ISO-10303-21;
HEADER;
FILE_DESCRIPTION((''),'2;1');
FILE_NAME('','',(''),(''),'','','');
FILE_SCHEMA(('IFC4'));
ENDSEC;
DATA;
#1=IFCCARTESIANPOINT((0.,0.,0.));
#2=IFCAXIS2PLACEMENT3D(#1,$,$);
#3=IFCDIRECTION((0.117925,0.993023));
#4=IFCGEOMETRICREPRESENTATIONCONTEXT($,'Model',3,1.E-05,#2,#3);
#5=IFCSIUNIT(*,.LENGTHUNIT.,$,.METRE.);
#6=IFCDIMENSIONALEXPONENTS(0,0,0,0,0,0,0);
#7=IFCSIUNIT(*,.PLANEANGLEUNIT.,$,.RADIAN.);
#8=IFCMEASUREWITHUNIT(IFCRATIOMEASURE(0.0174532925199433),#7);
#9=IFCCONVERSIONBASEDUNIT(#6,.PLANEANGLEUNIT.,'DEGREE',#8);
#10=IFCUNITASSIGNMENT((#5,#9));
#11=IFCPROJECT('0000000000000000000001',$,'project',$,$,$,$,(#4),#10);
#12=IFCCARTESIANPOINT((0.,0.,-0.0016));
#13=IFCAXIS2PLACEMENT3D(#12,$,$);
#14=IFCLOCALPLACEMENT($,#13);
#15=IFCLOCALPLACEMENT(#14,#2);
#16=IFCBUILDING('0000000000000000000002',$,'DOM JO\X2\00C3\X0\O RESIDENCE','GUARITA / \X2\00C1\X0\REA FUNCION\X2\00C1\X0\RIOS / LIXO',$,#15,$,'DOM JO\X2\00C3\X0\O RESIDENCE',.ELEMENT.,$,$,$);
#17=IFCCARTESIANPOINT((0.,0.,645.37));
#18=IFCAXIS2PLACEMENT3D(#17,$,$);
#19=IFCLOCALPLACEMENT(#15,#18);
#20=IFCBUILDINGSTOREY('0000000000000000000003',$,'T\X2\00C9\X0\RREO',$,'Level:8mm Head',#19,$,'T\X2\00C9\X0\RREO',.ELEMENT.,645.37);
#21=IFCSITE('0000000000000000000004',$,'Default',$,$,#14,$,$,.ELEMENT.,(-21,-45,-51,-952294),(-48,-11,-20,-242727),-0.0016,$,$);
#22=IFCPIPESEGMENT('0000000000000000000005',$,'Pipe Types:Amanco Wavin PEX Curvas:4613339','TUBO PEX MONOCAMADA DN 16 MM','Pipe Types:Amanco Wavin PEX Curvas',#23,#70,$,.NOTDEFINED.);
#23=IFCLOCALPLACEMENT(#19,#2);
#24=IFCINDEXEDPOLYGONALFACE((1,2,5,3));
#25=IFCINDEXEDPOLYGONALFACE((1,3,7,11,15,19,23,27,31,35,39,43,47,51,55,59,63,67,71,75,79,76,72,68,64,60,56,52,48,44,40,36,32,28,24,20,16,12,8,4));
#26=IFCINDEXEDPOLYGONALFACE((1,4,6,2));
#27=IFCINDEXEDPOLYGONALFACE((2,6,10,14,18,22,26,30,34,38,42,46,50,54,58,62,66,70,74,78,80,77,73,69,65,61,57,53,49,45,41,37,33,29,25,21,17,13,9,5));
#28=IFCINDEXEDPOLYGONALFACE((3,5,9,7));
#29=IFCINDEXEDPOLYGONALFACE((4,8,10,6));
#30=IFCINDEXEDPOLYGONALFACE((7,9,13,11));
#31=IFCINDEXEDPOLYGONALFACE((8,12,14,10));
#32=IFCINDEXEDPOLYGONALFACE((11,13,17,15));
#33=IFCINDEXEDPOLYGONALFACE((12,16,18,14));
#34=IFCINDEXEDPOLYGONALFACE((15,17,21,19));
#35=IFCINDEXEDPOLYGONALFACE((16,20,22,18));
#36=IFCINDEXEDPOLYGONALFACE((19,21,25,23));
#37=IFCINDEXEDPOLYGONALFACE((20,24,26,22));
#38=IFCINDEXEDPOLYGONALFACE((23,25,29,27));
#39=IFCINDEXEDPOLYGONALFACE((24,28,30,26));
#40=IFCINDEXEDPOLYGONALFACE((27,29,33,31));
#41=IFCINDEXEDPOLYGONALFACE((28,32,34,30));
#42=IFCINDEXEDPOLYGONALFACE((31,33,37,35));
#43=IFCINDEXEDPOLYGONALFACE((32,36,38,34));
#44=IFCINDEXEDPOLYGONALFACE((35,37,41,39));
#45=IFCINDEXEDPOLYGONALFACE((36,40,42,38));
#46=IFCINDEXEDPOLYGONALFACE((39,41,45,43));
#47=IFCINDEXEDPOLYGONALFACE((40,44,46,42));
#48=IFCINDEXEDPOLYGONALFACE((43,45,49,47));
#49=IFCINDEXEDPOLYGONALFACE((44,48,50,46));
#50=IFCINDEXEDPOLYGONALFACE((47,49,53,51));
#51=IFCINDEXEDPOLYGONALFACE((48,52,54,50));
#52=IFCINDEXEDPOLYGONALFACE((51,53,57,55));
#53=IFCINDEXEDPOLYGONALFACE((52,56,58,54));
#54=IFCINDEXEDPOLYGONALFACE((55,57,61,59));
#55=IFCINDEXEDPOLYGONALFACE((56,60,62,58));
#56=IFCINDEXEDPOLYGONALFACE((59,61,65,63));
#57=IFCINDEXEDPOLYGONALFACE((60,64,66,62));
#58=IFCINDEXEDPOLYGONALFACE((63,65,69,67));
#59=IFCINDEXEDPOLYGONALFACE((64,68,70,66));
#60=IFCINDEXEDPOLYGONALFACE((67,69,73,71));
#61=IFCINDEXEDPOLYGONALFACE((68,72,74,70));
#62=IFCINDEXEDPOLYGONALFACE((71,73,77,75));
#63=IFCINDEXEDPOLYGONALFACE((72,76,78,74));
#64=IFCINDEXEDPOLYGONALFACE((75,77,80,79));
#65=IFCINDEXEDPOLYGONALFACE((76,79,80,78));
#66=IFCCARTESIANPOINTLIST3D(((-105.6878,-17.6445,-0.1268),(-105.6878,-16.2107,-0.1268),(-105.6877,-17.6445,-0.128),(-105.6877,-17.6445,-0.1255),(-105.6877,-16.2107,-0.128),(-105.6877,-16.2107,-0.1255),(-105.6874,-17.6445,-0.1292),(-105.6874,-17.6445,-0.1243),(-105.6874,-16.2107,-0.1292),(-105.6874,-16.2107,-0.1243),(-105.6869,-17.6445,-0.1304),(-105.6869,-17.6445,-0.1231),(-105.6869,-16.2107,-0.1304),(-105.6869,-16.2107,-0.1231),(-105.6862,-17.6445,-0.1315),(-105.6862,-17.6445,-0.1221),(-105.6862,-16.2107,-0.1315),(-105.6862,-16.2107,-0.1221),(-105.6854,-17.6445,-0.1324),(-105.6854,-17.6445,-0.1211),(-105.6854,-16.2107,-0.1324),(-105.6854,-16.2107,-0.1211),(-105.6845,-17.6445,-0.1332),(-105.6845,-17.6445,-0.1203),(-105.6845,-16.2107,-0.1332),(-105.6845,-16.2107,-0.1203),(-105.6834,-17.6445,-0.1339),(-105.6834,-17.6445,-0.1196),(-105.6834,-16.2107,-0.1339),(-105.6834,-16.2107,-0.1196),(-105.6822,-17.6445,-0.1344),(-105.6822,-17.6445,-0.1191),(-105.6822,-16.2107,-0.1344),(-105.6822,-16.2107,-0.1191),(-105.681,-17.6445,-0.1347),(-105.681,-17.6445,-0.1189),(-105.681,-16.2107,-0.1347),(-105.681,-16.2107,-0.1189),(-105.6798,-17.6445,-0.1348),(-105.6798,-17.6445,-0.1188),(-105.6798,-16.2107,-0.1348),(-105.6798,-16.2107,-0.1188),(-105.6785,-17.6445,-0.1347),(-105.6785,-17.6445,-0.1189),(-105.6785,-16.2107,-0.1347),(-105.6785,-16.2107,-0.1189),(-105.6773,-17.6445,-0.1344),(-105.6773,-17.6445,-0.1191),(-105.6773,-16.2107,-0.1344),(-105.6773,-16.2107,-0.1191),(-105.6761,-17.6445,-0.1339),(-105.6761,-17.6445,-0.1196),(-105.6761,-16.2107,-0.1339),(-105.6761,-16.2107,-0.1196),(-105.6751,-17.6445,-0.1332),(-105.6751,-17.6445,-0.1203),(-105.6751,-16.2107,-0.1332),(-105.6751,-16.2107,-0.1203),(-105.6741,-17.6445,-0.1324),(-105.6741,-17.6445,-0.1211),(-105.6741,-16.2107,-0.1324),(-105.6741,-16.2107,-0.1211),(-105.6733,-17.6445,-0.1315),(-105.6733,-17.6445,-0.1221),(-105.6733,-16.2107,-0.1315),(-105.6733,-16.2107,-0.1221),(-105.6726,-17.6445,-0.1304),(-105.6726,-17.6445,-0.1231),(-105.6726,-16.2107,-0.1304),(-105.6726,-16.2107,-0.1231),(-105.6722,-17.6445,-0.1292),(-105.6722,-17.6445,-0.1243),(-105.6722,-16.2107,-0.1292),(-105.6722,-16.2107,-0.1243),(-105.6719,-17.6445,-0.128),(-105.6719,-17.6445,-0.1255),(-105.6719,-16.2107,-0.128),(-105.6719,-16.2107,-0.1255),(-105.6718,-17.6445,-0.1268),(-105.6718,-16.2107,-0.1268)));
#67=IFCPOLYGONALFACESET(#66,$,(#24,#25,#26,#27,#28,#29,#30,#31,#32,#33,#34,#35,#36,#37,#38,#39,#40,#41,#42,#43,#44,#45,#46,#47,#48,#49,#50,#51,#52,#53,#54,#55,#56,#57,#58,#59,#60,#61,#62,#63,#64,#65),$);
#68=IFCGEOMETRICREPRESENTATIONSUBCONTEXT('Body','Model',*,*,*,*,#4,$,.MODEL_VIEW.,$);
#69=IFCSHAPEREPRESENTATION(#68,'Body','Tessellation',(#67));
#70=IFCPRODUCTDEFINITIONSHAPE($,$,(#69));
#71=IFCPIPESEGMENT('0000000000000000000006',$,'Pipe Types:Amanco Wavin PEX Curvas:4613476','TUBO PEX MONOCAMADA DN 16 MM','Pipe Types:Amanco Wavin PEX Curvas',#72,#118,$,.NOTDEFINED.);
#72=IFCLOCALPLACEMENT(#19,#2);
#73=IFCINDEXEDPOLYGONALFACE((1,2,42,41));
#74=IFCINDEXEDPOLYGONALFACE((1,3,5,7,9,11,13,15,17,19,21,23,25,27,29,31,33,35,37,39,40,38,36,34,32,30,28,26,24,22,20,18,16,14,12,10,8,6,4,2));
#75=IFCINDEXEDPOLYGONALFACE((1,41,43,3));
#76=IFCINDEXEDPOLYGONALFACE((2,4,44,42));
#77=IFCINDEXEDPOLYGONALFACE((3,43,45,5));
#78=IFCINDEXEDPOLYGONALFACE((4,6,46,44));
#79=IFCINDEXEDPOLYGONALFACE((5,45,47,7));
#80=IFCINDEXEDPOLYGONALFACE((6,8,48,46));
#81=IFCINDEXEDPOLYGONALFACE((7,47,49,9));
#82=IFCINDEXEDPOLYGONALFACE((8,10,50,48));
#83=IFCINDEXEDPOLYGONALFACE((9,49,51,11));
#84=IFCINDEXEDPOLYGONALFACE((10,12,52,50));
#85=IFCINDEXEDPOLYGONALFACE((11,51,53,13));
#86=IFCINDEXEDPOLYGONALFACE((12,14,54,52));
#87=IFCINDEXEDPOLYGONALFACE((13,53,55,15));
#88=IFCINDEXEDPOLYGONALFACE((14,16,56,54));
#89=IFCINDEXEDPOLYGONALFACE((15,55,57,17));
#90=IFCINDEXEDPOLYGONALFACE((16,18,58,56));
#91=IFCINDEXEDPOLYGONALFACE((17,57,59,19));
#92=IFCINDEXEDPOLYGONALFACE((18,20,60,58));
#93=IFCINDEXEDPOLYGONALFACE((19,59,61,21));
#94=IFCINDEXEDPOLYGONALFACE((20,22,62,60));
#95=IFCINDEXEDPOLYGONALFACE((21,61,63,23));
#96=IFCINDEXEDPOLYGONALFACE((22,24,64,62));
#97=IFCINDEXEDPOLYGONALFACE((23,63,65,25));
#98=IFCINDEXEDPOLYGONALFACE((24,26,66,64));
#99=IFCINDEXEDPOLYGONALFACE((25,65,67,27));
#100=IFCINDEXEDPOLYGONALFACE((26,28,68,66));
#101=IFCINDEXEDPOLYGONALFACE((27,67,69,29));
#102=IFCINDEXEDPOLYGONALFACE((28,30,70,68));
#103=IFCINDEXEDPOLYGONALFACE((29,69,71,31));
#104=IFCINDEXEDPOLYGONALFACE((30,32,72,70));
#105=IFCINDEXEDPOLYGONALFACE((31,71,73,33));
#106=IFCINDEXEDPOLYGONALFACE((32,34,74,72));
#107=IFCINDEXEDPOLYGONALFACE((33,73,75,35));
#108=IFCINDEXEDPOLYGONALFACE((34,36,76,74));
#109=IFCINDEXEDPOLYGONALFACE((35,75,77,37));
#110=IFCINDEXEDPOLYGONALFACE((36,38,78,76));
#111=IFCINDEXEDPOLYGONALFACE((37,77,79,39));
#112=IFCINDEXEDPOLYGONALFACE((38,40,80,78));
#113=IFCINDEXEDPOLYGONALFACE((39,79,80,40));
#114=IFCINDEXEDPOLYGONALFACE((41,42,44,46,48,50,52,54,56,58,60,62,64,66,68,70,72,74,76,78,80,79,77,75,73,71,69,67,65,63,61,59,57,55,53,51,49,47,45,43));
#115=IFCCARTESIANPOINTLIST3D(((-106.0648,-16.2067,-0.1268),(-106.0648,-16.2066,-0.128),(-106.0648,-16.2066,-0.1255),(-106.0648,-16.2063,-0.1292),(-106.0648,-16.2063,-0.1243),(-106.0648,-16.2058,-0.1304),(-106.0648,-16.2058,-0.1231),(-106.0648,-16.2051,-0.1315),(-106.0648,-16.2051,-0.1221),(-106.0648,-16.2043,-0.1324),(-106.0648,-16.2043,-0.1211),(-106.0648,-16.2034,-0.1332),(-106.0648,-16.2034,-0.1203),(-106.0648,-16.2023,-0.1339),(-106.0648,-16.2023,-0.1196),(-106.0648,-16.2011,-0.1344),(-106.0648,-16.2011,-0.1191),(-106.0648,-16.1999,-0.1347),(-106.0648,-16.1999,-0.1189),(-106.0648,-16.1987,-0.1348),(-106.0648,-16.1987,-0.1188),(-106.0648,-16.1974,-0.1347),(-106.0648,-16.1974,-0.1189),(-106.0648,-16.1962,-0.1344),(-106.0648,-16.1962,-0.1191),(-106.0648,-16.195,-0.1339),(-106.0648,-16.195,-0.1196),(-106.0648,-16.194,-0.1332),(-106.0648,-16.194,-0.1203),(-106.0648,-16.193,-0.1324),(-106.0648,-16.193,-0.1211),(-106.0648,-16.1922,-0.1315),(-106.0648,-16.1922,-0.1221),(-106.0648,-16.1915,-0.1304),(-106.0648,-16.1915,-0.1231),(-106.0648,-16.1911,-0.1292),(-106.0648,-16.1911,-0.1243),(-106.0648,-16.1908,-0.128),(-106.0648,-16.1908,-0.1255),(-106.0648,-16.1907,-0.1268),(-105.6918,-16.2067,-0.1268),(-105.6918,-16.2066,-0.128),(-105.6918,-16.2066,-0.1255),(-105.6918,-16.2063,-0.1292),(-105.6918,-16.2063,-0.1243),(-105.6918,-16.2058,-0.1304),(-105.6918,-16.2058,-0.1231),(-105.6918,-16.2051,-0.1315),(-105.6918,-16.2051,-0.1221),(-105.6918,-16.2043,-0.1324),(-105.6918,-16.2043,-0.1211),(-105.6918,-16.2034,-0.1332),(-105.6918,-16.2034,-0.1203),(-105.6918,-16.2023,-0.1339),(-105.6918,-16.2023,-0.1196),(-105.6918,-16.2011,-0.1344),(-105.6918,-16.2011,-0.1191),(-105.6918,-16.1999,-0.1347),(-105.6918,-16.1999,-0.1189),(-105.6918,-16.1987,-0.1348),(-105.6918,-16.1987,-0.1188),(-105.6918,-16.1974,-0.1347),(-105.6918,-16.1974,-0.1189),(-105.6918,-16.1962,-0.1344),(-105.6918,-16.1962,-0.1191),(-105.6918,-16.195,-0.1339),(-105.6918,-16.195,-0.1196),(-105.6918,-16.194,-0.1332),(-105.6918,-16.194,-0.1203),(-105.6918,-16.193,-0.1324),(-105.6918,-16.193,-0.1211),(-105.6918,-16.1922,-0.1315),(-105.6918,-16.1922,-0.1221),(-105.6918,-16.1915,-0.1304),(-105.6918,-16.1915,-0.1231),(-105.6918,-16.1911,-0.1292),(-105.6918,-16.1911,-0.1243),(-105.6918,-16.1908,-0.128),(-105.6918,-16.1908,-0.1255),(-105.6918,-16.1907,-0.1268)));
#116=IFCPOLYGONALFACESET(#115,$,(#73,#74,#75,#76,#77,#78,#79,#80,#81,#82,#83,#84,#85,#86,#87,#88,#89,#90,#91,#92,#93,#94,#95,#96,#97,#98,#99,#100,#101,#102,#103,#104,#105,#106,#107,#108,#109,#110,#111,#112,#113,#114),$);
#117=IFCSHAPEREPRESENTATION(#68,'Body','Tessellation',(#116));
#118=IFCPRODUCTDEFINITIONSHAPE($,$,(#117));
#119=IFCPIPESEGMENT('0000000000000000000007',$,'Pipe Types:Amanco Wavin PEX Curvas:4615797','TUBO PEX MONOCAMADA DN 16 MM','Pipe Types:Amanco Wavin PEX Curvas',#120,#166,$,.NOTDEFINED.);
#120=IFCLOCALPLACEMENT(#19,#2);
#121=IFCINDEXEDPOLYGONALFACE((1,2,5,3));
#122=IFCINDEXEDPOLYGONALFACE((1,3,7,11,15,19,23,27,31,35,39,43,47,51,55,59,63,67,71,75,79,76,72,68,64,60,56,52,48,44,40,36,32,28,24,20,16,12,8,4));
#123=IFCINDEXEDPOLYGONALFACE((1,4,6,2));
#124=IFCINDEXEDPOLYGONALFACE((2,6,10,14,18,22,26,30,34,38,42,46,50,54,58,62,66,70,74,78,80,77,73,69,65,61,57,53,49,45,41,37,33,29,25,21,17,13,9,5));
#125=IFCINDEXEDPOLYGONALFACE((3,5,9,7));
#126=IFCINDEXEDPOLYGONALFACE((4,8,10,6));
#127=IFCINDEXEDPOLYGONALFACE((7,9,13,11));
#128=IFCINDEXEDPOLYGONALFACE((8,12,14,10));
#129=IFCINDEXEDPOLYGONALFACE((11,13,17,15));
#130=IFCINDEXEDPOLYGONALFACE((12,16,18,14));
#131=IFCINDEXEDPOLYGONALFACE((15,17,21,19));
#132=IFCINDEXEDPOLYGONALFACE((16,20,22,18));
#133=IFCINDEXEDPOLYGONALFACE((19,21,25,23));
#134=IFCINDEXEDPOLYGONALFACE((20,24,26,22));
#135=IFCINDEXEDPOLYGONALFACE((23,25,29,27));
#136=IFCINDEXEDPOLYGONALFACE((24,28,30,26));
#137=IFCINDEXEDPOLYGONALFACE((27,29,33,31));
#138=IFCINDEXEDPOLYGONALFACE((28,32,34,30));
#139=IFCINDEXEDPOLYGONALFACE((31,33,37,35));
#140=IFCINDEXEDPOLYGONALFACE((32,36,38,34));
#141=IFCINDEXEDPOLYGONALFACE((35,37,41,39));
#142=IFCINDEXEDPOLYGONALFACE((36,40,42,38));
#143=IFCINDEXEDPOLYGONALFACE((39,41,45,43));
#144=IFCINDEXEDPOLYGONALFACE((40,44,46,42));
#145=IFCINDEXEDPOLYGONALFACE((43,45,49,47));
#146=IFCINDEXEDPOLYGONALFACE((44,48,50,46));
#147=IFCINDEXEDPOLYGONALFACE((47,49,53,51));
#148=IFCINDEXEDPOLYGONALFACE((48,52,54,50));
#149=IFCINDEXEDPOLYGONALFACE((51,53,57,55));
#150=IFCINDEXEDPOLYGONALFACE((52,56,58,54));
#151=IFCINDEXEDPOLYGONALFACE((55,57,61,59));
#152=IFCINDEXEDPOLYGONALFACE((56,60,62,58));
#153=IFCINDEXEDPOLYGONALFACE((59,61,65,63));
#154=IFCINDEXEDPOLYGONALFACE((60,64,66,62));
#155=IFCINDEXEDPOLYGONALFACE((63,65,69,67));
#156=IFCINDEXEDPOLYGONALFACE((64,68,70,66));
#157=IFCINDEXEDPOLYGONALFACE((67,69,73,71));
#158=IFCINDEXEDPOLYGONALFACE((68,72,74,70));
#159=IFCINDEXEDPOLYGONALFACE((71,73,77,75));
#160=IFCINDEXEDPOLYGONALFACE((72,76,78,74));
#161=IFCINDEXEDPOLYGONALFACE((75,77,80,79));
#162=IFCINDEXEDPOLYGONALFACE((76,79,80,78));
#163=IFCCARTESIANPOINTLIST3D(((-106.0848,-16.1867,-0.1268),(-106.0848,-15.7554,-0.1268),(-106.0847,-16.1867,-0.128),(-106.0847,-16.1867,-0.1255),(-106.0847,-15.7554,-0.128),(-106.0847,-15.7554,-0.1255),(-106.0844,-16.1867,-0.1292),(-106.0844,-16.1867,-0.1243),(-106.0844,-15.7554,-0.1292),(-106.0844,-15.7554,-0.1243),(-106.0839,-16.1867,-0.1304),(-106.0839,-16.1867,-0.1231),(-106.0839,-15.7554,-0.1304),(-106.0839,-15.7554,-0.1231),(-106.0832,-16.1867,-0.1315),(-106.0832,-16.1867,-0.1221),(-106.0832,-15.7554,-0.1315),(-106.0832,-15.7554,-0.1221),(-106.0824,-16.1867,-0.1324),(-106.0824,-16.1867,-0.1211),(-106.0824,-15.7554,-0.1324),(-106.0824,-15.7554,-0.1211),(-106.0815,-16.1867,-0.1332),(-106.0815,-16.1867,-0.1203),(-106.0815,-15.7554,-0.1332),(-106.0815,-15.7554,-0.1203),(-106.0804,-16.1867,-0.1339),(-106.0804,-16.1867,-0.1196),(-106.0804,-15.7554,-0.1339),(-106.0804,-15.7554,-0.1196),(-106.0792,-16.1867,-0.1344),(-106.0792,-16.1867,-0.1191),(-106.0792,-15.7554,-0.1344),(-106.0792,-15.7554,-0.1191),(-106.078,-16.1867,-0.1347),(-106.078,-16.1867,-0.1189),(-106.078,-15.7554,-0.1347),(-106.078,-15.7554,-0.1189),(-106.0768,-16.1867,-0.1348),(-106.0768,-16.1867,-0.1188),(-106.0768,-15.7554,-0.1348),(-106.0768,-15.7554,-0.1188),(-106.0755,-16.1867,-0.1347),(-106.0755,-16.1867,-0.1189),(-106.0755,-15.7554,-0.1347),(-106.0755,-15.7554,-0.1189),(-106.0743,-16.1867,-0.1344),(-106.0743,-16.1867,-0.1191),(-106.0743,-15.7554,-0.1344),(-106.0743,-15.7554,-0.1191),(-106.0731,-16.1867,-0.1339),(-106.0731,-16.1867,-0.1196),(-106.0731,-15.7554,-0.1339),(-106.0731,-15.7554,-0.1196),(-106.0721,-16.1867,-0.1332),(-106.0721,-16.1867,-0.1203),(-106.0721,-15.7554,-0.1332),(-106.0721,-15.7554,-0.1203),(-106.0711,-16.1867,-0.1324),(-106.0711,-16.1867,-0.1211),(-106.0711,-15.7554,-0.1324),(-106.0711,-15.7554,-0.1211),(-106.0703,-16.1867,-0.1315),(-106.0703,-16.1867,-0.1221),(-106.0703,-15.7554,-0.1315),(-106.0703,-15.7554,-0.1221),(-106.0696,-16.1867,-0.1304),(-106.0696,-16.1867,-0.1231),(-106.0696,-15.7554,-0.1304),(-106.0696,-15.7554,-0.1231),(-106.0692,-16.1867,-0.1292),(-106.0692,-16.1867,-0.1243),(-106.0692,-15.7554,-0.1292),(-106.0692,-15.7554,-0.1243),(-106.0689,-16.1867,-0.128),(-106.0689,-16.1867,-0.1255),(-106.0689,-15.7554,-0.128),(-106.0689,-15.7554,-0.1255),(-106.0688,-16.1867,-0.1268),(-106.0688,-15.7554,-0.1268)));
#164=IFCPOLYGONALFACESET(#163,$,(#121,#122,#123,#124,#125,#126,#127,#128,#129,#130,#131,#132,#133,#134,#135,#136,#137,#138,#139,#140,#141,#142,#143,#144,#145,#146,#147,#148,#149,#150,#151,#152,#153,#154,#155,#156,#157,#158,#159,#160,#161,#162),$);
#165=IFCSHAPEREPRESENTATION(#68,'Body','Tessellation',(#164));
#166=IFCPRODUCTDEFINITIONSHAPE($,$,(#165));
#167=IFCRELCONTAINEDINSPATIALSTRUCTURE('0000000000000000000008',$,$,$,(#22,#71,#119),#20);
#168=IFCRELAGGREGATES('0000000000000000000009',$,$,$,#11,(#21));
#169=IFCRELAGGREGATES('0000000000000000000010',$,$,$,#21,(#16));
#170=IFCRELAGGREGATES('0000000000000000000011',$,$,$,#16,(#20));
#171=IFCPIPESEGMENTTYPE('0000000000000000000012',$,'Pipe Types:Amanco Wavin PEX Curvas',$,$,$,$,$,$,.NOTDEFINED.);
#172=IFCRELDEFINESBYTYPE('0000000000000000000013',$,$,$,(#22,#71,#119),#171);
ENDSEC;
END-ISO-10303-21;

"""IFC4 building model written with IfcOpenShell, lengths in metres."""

from ifc_helpers import new_model, entity, si_unit, converted_unit, direction, frame, origin, place, context, subcontext, project, spatial, indexed_curve, outline, extrude, type_object, element, save


model = new_model("IFC4")

# Units and contexts
model_context = context("Model", 3, precision=1e-05, world=origin(), true_north=direction((0.117925, 0.993023)))
body_context = subcontext(model_context, "Body", "Model", "MODEL_VIEW")
ifc_project = project(units=[si_unit("LENGTHUNIT", "METRE"), converted_unit("PLANEANGLEUNIT", "DEGREE", entity("IfcRatioMeasure", 0.0174532925199433), si_unit("PLANEANGLEUNIT", "RADIAN"), dimensions=[0, 0, 0, 0, 0, 0, 0])], contexts=[model_context])

# Site, building, storey
site_placement = place(None, frame((0.0, 0.0, -0.0016)))
site = spatial("IfcSite", under=ifc_project, at=site_placement, Name="Default", CompositionType="ELEMENT", RefLatitude=(-21, -45, -51, -952294), RefLongitude=(-48, -11, -20, -242727), RefElevation=-0.0016)
building_placement = place(site_placement, origin())
building = spatial("IfcBuilding", under=site, at=building_placement, Name="DOM JOÃO RESIDENCE", Description="GUARITA / ÁREA FUNCIONÁRIOS / LIXO", LongName="DOM JOÃO RESIDENCE", CompositionType="ELEMENT")
storey_placement = place(building_placement, frame((0.0, 0.0, 645.37)))
storey = spatial("IfcBuildingStorey", under=building, at=storey_placement, Name="TÉRREO", ObjectType="Level:8mm Head", LongName="TÉRREO", CompositionType="ELEMENT", Elevation=645.37)

# Pipe segments
pipe_segment_type_1 = type_object("IfcPipeSegmentType", Name="Pipe Types:Amanco Wavin PEX Curvas", PredefinedType="NOTDEFINED")
pipe_segment_1_placement = place(storey_placement, frame((-105.6894, -17.6445, -0.1364)))
element("IfcPipeSegment", 1, at=pipe_segment_1_placement, inside=storey, type_object=pipe_segment_type_1, Name="Pipe Types:Amanco Wavin PEX Curvas:4613339", Description="TUBO PEX MONOCAMADA DN 16 MM", ObjectType="Pipe Types:Amanco Wavin PEX Curvas", PredefinedType="NOTDEFINED", context=body_context, shape_type="SweptSolid", body=[
    extrude(outline(indexed_curve([(0.008, 0.0), (0.0079, 0.0013), (0.0076, 0.0025), (0.0071, 0.0036), (0.0065, 0.0047), (0.0057, 0.0057), (0.0047, 0.0065), (0.0036, 0.0071), (0.0025, 0.0076), (0.0013, 0.0079), (0.0, 0.008), (-0.0013, 0.0079), (-0.0025, 0.0076), (-0.0036, 0.0071), (-0.0047, 0.0065), (-0.0057, 0.0057), (-0.0065, 0.0047), (-0.0071, 0.0036), (-0.0076, 0.0025), (-0.0079, 0.0013), (-0.008, 0.0), (-0.0079, -0.0013), (-0.0076, -0.0025), (-0.0071, -0.0036), (-0.0065, -0.0047), (-0.0057, -0.0057), (-0.0047, -0.0065), (-0.0036, -0.0071), (-0.0025, -0.0076), (-0.0013, -0.0079), (0.0, -0.008), (0.0013, -0.0079), (0.0025, -0.0076), (0.0036, -0.0071), (0.0047, -0.0065), (0.0057, -0.0057), (0.0065, -0.0047), (0.0071, -0.0036), (0.0076, -0.0025), (0.0079, -0.0013), (0.008, 0.0)], self_intersect=False)), frame((0.0096, 0.0, 0.0096), z_axis=(0.0, 1.0, 0.0), x_axis=(-1.0, 0.0, 0.0)), (0.0, 0.0, 1.0), 1.4338),
])
pipe_segment_2_placement = place(storey_placement, frame((-106.0648, -16.2083, -0.1364)))
element("IfcPipeSegment", 2, at=pipe_segment_2_placement, inside=storey, type_object=pipe_segment_type_1, Name="Pipe Types:Amanco Wavin PEX Curvas:4613476", Description="TUBO PEX MONOCAMADA DN 16 MM", ObjectType="Pipe Types:Amanco Wavin PEX Curvas", PredefinedType="NOTDEFINED", context=body_context, shape_type="SweptSolid", body=[
    extrude(outline(indexed_curve([(0.008, 0.0), (0.0079, 0.0013), (0.0076, 0.0025), (0.0071, 0.0036), (0.0065, 0.0047), (0.0057, 0.0057), (0.0047, 0.0065), (0.0036, 0.0071), (0.0025, 0.0076), (0.0013, 0.0079), (0.0, 0.008), (-0.0013, 0.0079), (-0.0025, 0.0076), (-0.0036, 0.0071), (-0.0047, 0.0065), (-0.0057, 0.0057), (-0.0065, 0.0047), (-0.0071, 0.0036), (-0.0076, 0.0025), (-0.0079, 0.0013), (-0.008, 0.0), (-0.0079, -0.0013), (-0.0076, -0.0025), (-0.0071, -0.0036), (-0.0065, -0.0047), (-0.0057, -0.0057), (-0.0047, -0.0065), (-0.0036, -0.0071), (-0.0025, -0.0076), (-0.0013, -0.0079), (0.0, -0.008), (0.0013, -0.0079), (0.0025, -0.0076), (0.0036, -0.0071), (0.0047, -0.0065), (0.0057, -0.0057), (0.0065, -0.0047), (0.0071, -0.0036), (0.0076, -0.0025), (0.0079, -0.0013), (0.008, 0.0)], self_intersect=False)), frame((0.0, 0.0096, 0.0096), z_axis=(1.0, 0.0, 0.0), x_axis=(0.0, -1.0, 0.0)), (0.0, 0.0, 1.0), 0.373),
])
pipe_segment_3_placement = place(storey_placement, frame((-106.0864, -16.1867, -0.1364)))
element("IfcPipeSegment", 3, at=pipe_segment_3_placement, inside=storey, type_object=pipe_segment_type_1, Name="Pipe Types:Amanco Wavin PEX Curvas:4615797", Description="TUBO PEX MONOCAMADA DN 16 MM", ObjectType="Pipe Types:Amanco Wavin PEX Curvas", PredefinedType="NOTDEFINED", context=body_context, shape_type="SweptSolid", body=[
    extrude(outline(indexed_curve([(0.008, 0.0), (0.0079, 0.0013), (0.0076, 0.0025), (0.0071, 0.0036), (0.0065, 0.0047), (0.0057, 0.0057), (0.0047, 0.0065), (0.0036, 0.0071), (0.0025, 0.0076), (0.0013, 0.0079), (0.0, 0.008), (-0.0013, 0.0079), (-0.0025, 0.0076), (-0.0036, 0.0071), (-0.0047, 0.0065), (-0.0057, 0.0057), (-0.0065, 0.0047), (-0.0071, 0.0036), (-0.0076, 0.0025), (-0.0079, 0.0013), (-0.008, 0.0), (-0.0079, -0.0013), (-0.0076, -0.0025), (-0.0071, -0.0036), (-0.0065, -0.0047), (-0.0057, -0.0057), (-0.0047, -0.0065), (-0.0036, -0.0071), (-0.0025, -0.0076), (-0.0013, -0.0079), (0.0, -0.008), (0.0013, -0.0079), (0.0025, -0.0076), (0.0036, -0.0071), (0.0047, -0.0065), (0.0057, -0.0057), (0.0065, -0.0047), (0.0071, -0.0036), (0.0076, -0.0025), (0.0079, -0.0013), (0.008, 0.0)], self_intersect=False)), frame((0.0096, 0.0, 0.0096), z_axis=(0.0, 1.0, 0.0), x_axis=(1.0, 0.0, 0.0)), (0.0, 0.0, 1.0), 0.4313),
])

save(model, "model.ifc")
